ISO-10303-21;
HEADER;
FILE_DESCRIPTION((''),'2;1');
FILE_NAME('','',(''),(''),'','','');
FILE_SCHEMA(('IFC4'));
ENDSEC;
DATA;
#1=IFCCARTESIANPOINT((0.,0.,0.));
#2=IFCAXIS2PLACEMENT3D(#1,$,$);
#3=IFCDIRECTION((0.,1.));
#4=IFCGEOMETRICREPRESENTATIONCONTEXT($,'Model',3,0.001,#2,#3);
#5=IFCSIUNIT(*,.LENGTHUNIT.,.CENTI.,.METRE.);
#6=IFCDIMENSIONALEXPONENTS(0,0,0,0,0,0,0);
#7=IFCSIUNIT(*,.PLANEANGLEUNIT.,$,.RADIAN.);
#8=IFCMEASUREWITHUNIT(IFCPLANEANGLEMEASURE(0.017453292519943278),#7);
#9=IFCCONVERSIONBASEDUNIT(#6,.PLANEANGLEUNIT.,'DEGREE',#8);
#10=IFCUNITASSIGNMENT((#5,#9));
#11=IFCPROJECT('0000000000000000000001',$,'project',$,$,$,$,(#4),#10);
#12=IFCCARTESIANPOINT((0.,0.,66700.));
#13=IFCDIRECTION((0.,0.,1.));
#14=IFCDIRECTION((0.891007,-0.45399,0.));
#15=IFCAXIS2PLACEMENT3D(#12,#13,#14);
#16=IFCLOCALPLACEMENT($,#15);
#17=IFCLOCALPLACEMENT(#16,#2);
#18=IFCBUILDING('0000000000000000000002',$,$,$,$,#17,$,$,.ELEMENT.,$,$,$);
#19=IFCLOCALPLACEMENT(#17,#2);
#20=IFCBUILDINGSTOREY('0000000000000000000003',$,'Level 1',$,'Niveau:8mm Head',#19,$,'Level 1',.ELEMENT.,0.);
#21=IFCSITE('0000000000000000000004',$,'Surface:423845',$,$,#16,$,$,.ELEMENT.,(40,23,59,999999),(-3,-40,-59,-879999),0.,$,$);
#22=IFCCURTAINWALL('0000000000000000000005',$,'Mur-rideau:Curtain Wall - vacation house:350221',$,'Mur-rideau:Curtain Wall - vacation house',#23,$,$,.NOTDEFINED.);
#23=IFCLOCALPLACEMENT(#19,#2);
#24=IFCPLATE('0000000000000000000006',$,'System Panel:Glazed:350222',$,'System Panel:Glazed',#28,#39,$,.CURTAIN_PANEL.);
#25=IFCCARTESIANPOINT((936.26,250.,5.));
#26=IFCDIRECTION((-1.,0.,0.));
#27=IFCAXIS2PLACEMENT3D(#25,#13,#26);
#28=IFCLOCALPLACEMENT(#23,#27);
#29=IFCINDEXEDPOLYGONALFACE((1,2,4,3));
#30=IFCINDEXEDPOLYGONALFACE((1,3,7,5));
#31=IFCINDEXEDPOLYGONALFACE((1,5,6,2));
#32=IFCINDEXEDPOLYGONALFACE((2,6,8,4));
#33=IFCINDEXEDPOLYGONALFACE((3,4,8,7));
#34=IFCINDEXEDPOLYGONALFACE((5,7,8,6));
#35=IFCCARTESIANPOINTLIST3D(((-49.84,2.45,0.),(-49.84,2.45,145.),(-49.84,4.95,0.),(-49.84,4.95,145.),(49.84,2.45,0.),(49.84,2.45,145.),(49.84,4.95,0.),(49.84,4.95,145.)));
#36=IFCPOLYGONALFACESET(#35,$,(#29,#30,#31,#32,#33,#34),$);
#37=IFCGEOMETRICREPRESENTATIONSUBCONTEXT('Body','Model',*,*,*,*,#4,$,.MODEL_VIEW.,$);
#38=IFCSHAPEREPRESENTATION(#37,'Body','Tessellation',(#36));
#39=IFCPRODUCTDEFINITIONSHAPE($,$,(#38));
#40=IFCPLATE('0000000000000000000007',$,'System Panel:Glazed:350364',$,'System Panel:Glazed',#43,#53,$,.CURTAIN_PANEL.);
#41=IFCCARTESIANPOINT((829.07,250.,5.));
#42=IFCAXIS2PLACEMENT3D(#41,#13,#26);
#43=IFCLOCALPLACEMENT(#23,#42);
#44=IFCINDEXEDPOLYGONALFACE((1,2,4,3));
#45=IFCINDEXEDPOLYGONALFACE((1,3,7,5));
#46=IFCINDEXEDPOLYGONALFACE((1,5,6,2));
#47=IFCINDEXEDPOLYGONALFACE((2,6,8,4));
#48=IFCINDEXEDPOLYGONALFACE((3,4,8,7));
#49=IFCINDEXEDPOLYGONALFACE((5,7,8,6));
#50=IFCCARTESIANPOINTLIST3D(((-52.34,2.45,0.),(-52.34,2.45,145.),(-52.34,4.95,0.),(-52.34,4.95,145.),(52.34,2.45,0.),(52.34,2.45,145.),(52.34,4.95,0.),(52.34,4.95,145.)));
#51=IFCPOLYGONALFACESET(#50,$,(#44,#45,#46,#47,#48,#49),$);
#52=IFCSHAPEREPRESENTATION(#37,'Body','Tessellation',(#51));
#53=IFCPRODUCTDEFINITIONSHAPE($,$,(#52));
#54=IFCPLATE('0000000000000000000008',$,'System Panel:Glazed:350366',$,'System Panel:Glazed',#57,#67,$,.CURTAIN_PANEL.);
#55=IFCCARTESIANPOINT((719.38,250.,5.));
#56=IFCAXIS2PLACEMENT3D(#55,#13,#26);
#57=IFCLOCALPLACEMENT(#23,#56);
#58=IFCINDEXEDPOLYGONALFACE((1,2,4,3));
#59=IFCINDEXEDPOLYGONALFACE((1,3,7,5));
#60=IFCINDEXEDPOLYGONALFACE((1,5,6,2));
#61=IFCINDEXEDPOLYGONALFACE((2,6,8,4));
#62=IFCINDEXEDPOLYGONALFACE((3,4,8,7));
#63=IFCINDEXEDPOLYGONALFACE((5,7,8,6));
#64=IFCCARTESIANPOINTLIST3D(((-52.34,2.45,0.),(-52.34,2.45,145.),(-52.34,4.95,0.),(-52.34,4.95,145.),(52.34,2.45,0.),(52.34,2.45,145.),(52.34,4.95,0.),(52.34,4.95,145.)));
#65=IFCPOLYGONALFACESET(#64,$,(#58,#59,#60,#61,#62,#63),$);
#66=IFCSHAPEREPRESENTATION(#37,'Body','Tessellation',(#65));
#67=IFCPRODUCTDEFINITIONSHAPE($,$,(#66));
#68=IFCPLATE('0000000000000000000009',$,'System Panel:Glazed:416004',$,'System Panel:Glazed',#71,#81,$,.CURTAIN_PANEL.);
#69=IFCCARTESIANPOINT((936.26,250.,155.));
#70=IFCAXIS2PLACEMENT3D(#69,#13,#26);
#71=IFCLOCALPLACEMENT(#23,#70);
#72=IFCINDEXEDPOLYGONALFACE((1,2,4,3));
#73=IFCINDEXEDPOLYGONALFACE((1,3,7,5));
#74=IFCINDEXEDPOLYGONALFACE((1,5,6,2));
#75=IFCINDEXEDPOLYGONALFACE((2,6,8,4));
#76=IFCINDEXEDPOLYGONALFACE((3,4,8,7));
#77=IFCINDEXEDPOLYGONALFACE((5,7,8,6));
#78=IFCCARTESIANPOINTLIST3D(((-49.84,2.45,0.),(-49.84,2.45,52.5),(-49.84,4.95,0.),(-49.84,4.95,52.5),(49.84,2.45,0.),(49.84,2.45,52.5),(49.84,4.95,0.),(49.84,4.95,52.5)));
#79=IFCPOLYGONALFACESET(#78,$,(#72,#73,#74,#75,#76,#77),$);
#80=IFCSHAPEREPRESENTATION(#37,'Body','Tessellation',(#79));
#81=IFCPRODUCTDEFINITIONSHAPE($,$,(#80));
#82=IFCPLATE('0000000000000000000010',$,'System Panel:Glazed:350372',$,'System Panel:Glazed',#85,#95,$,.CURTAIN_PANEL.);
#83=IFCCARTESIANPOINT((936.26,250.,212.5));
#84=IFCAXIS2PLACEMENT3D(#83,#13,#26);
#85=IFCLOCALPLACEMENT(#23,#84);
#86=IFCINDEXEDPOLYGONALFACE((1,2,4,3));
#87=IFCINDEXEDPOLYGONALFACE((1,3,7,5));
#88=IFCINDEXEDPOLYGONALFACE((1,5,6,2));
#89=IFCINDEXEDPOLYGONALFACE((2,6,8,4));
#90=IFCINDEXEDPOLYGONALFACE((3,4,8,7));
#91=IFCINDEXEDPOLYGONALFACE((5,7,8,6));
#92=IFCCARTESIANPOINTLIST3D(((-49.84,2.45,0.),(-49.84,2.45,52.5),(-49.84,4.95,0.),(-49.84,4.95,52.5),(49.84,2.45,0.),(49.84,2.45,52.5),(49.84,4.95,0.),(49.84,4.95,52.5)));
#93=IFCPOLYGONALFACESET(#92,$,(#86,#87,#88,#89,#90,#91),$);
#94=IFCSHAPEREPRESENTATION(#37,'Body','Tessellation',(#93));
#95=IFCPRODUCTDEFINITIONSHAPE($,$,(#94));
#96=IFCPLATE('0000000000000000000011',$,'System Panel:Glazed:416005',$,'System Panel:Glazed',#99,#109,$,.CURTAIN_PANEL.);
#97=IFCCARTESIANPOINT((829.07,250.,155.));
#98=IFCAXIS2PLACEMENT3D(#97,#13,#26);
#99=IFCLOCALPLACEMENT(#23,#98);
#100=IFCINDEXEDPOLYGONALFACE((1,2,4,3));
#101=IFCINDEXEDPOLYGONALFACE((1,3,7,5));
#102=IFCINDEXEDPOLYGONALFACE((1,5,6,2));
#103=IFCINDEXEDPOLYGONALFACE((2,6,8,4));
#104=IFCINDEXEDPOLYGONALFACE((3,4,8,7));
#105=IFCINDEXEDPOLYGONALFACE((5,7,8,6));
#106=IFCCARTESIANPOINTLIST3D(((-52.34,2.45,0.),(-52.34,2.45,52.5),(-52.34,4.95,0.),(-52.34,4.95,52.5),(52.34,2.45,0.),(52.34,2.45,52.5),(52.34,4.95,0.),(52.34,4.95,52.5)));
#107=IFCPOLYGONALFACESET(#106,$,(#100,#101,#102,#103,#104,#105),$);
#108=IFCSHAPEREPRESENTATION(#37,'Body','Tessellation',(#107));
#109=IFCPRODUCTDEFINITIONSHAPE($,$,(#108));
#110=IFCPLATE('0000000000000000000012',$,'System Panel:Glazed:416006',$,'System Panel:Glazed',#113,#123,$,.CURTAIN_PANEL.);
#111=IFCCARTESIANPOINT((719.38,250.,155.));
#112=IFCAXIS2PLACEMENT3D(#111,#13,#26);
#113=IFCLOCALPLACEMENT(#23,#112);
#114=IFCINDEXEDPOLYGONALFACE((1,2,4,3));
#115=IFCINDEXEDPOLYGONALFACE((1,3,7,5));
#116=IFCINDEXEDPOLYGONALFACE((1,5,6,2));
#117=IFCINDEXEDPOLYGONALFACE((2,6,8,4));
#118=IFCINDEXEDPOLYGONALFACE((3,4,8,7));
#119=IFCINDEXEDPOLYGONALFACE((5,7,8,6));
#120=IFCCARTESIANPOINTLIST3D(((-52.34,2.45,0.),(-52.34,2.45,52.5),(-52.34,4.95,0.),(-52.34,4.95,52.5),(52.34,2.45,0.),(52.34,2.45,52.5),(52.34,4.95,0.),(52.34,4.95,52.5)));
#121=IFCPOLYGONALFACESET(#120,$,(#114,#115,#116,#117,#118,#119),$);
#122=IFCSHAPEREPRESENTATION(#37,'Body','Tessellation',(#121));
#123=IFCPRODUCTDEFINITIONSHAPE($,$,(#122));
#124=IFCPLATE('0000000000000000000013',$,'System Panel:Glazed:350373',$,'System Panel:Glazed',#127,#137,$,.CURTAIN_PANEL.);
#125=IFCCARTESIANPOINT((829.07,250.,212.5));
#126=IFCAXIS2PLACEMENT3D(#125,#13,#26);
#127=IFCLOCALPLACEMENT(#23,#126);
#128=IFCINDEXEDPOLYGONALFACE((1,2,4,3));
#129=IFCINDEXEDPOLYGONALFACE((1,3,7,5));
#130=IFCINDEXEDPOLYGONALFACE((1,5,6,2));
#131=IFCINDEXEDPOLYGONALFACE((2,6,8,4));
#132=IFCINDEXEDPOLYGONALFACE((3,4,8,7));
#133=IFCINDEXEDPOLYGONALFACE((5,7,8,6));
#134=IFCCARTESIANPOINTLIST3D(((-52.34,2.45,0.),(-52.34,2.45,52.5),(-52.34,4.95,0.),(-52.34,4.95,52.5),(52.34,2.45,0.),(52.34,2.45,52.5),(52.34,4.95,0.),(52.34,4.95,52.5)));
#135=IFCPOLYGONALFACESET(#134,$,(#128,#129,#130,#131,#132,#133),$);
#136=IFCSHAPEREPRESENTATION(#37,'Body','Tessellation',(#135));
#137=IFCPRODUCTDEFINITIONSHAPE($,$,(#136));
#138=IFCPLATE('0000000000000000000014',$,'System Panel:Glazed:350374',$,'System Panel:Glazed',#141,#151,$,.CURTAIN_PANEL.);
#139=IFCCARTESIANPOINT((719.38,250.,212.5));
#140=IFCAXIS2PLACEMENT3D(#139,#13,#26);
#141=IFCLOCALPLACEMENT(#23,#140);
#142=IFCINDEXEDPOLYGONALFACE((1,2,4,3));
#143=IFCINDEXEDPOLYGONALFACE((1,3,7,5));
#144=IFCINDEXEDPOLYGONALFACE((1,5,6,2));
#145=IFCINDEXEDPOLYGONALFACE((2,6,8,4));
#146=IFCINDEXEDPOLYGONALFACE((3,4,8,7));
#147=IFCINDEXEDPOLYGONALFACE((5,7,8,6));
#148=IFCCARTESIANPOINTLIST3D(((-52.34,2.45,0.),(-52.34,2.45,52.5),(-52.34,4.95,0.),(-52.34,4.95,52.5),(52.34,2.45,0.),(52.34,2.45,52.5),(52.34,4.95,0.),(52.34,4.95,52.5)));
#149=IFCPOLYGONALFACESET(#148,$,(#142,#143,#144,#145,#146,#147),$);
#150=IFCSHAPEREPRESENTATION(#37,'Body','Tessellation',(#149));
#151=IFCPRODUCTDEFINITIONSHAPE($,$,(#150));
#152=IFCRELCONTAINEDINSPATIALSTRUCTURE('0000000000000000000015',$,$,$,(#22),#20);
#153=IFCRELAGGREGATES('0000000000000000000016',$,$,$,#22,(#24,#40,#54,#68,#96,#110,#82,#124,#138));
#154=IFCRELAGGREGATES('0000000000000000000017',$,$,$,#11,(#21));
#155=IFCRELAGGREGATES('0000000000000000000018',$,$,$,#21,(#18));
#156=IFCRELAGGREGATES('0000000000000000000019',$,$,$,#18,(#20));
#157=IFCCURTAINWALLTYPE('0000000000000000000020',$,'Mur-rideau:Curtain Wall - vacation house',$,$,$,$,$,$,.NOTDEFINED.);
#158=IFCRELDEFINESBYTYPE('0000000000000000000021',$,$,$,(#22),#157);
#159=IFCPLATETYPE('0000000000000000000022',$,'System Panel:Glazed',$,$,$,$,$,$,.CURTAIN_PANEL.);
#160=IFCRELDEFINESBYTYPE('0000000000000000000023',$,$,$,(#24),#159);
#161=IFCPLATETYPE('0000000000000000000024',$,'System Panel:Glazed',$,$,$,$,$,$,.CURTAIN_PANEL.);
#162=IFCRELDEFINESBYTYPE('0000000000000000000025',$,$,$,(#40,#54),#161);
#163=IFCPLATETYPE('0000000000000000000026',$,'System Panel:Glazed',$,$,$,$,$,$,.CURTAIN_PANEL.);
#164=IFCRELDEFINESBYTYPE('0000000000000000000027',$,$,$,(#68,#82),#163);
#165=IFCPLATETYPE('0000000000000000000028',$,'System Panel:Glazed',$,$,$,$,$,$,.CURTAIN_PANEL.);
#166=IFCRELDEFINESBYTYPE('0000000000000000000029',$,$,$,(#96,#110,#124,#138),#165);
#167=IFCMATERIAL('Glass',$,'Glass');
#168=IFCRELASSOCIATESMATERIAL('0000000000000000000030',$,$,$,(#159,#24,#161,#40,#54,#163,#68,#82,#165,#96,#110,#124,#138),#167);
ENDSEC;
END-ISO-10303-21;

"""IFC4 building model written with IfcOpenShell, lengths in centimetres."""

from ifc_helpers import new_model, entity, si_unit, converted_unit, direction, frame, origin, origin_2d_with_axis, place, context, subcontext, project, spatial, rectangle, extrude, source, transform, mapped, material, type_object, type_shapes, element, aggregate, save


model = new_model("IFC4")

# Units and contexts
model_context = context("Model", 3, precision=0.001, world=origin(), true_north=direction((0.0, 1.0)))
body_context = subcontext(model_context, "Body", "Model", "MODEL_VIEW")
ifc_project = project(units=[si_unit("LENGTHUNIT", "METRE", prefix="CENTI"), converted_unit("PLANEANGLEUNIT", "DEGREE", entity("IfcPlaneAngleMeasure", 0.017453292519943278), si_unit("PLANEANGLEUNIT", "RADIAN"), dimensions=[0, 0, 0, 0, 0, 0, 0])], contexts=[model_context])

# Site, building, storey
site_placement = place(None, frame((0.0, 0.0, 66700.0), z_axis=(0.0, 0.0, 1.0), x_axis=(0.891007, -0.45399, 0.0)))
site = spatial("IfcSite", under=ifc_project, at=site_placement, Name="Surface:423845", CompositionType="ELEMENT", RefLatitude=(40, 23, 59, 999999), RefLongitude=(-3, -40, -59, -879999), RefElevation=0.0)
building_placement = place(site_placement, origin())
building = spatial("IfcBuilding", under=site, at=building_placement, CompositionType="ELEMENT")
storey_placement = place(building_placement, origin())
storey = spatial("IfcBuildingStorey", under=building, at=storey_placement, Name="Level 1", ObjectType="Niveau:8mm Head", LongName="Level 1", CompositionType="ELEMENT", Elevation=0.0)

# Curtain wall, plates
curtain_wall_type = type_object("IfcCurtainWallType", Name="Mur-rideau:Curtain Wall - vacation house", PredefinedType="NOTDEFINED")
curtain_wall_placement = place(storey_placement, origin())
curtain_wall = element("IfcCurtainWall", 1, at=curtain_wall_placement, inside=storey, type_object=curtain_wall_type, Name="Mur-rideau:Curtain Wall - vacation house:350221", ObjectType="Mur-rideau:Curtain Wall - vacation house", PredefinedType="NOTDEFINED")
ifc_material_1 = material(Name="Glass", Category="Glass")
plate_type_1 = type_object("IfcPlateType", Name="System Panel:Glazed", PredefinedType="CURTAIN_PANEL", material=ifc_material_1)
shared_shape_1 = source(origin(), body_context, "Body", "SweptSolid", [
    extrude(rectangle(XDim=2.5, YDim=99.69, at=origin_2d_with_axis()), frame((0.0, 3.7, 0.0), z_axis=(0.0, 0.0, 1.0), x_axis=(0.0, 1.0, 0.0)), (0.0, 0.0, 1.0), 145.0),
])
type_shapes(plate_type_1, [shared_shape_1])
plate_1_placement = place(curtain_wall_placement, frame((936.26, 250.0, 5.0), z_axis=(0.0, 0.0, 1.0), x_axis=(-1.0, 0.0, 0.0)))
plate_1 = element("IfcPlate", 2, at=plate_1_placement, type_object=plate_type_1, material=ifc_material_1, Name="System Panel:Glazed:350222", ObjectType="System Panel:Glazed", PredefinedType="CURTAIN_PANEL", context=body_context, shape_type="MappedRepresentation", body=[
    mapped(shared_shape_1, transform((0.0, 0.0, 0.0), scale=1.0)),
])
plate_type_2 = type_object("IfcPlateType", Name="System Panel:Glazed", PredefinedType="CURTAIN_PANEL", material=ifc_material_1)
shared_shape_2 = source(origin(), body_context, "Body", "SweptSolid", [
    extrude(rectangle(XDim=2.5, YDim=104.69, at=origin_2d_with_axis()), frame((0.0, 3.7, 0.0), z_axis=(0.0, 0.0, 1.0), x_axis=(0.0, 1.0, 0.0)), (0.0, 0.0, 1.0), 145.0),
])
type_shapes(plate_type_2, [shared_shape_2])
plate_2_placement = place(curtain_wall_placement, frame((829.07, 250.0, 5.0), z_axis=(0.0, 0.0, 1.0), x_axis=(-1.0, 0.0, 0.0)))
plate_2 = element("IfcPlate", 3, at=plate_2_placement, type_object=plate_type_2, material=ifc_material_1, Name="System Panel:Glazed:350364", ObjectType="System Panel:Glazed", PredefinedType="CURTAIN_PANEL", context=body_context, shape_type="MappedRepresentation", body=[
    mapped(shared_shape_2, transform((0.0, 0.0, 0.0), scale=1.0)),
])
plate_3_placement = place(curtain_wall_placement, frame((719.38, 250.0, 5.0), z_axis=(0.0, 0.0, 1.0), x_axis=(-1.0, 0.0, 0.0)))
plate_3 = element("IfcPlate", 4, at=plate_3_placement, type_object=plate_type_2, material=ifc_material_1, Name="System Panel:Glazed:350366", ObjectType="System Panel:Glazed", PredefinedType="CURTAIN_PANEL", context=body_context, shape_type="MappedRepresentation", body=[
    mapped(shared_shape_2, transform((0.0, 0.0, 0.0), scale=1.0)),
])
plate_type_3 = type_object("IfcPlateType", Name="System Panel:Glazed", PredefinedType="CURTAIN_PANEL", material=ifc_material_1)
shared_shape_3 = source(origin(), body_context, "Body", "SweptSolid", [
    extrude(rectangle(XDim=2.5, YDim=99.69, at=origin_2d_with_axis()), frame((0.0, 3.7, 0.0), z_axis=(0.0, 0.0, 1.0), x_axis=(0.0, 1.0, 0.0)), (0.0, 0.0, 1.0), 52.5),
])
type_shapes(plate_type_3, [shared_shape_3])
plate_4_placement = place(curtain_wall_placement, frame((936.26, 250.0, 155.0), z_axis=(0.0, 0.0, 1.0), x_axis=(-1.0, 0.0, 0.0)))
plate_4 = element("IfcPlate", 5, at=plate_4_placement, type_object=plate_type_3, material=ifc_material_1, Name="System Panel:Glazed:416004", ObjectType="System Panel:Glazed", PredefinedType="CURTAIN_PANEL", context=body_context, shape_type="MappedRepresentation", body=[
    mapped(shared_shape_3, transform((0.0, 0.0, 0.0), scale=1.0)),
])
plate_5_placement = place(curtain_wall_placement, frame((936.26, 250.0, 212.5), z_axis=(0.0, 0.0, 1.0), x_axis=(-1.0, 0.0, 0.0)))
plate_5 = element("IfcPlate", 6, at=plate_5_placement, type_object=plate_type_3, material=ifc_material_1, Name="System Panel:Glazed:350372", ObjectType="System Panel:Glazed", PredefinedType="CURTAIN_PANEL", context=body_context, shape_type="MappedRepresentation", body=[
    mapped(shared_shape_3, transform((0.0, 0.0, 0.0), scale=1.0)),
])
plate_type_4 = type_object("IfcPlateType", Name="System Panel:Glazed", PredefinedType="CURTAIN_PANEL", material=ifc_material_1)
shared_shape_4 = source(origin(), body_context, "Body", "SweptSolid", [
    extrude(rectangle(XDim=2.5, YDim=104.69, at=origin_2d_with_axis()), frame((0.0, 3.7, 0.0), z_axis=(0.0, 0.0, 1.0), x_axis=(0.0, 1.0, 0.0)), (0.0, 0.0, 1.0), 52.5),
])
type_shapes(plate_type_4, [shared_shape_4])
plate_6_placement = place(curtain_wall_placement, frame((829.07, 250.0, 155.0), z_axis=(0.0, 0.0, 1.0), x_axis=(-1.0, 0.0, 0.0)))
plate_6 = element("IfcPlate", 7, at=plate_6_placement, type_object=plate_type_4, material=ifc_material_1, Name="System Panel:Glazed:416005", ObjectType="System Panel:Glazed", PredefinedType="CURTAIN_PANEL", context=body_context, shape_type="MappedRepresentation", body=[
    mapped(shared_shape_4, transform((0.0, 0.0, 0.0), scale=1.0)),
])
plate_7_placement = place(curtain_wall_placement, frame((719.38, 250.0, 155.0), z_axis=(0.0, 0.0, 1.0), x_axis=(-1.0, 0.0, 0.0)))
plate_7 = element("IfcPlate", 8, at=plate_7_placement, type_object=plate_type_4, material=ifc_material_1, Name="System Panel:Glazed:416006", ObjectType="System Panel:Glazed", PredefinedType="CURTAIN_PANEL", context=body_context, shape_type="MappedRepresentation", body=[
    mapped(shared_shape_4, transform((0.0, 0.0, 0.0), scale=1.0)),
])
plate_8_placement = place(curtain_wall_placement, frame((829.07, 250.0, 212.5), z_axis=(0.0, 0.0, 1.0), x_axis=(-1.0, 0.0, 0.0)))
plate_8 = element("IfcPlate", 9, at=plate_8_placement, type_object=plate_type_4, material=ifc_material_1, Name="System Panel:Glazed:350373", ObjectType="System Panel:Glazed", PredefinedType="CURTAIN_PANEL", context=body_context, shape_type="MappedRepresentation", body=[
    mapped(shared_shape_4, transform((0.0, 0.0, 0.0), scale=1.0)),
])
plate_9_placement = place(curtain_wall_placement, frame((719.38, 250.0, 212.5), z_axis=(0.0, 0.0, 1.0), x_axis=(-1.0, 0.0, 0.0)))
plate_9 = element("IfcPlate", 10, at=plate_9_placement, type_object=plate_type_4, material=ifc_material_1, Name="System Panel:Glazed:350374", ObjectType="System Panel:Glazed", PredefinedType="CURTAIN_PANEL", context=body_context, shape_type="MappedRepresentation", body=[
    mapped(shared_shape_4, transform((0.0, 0.0, 0.0), scale=1.0)),
])
aggregate(curtain_wall, [plate_1, plate_2, plate_3, plate_4, plate_6, plate_7, plate_5, plate_8, plate_9])

save(model, "model.ifc")
